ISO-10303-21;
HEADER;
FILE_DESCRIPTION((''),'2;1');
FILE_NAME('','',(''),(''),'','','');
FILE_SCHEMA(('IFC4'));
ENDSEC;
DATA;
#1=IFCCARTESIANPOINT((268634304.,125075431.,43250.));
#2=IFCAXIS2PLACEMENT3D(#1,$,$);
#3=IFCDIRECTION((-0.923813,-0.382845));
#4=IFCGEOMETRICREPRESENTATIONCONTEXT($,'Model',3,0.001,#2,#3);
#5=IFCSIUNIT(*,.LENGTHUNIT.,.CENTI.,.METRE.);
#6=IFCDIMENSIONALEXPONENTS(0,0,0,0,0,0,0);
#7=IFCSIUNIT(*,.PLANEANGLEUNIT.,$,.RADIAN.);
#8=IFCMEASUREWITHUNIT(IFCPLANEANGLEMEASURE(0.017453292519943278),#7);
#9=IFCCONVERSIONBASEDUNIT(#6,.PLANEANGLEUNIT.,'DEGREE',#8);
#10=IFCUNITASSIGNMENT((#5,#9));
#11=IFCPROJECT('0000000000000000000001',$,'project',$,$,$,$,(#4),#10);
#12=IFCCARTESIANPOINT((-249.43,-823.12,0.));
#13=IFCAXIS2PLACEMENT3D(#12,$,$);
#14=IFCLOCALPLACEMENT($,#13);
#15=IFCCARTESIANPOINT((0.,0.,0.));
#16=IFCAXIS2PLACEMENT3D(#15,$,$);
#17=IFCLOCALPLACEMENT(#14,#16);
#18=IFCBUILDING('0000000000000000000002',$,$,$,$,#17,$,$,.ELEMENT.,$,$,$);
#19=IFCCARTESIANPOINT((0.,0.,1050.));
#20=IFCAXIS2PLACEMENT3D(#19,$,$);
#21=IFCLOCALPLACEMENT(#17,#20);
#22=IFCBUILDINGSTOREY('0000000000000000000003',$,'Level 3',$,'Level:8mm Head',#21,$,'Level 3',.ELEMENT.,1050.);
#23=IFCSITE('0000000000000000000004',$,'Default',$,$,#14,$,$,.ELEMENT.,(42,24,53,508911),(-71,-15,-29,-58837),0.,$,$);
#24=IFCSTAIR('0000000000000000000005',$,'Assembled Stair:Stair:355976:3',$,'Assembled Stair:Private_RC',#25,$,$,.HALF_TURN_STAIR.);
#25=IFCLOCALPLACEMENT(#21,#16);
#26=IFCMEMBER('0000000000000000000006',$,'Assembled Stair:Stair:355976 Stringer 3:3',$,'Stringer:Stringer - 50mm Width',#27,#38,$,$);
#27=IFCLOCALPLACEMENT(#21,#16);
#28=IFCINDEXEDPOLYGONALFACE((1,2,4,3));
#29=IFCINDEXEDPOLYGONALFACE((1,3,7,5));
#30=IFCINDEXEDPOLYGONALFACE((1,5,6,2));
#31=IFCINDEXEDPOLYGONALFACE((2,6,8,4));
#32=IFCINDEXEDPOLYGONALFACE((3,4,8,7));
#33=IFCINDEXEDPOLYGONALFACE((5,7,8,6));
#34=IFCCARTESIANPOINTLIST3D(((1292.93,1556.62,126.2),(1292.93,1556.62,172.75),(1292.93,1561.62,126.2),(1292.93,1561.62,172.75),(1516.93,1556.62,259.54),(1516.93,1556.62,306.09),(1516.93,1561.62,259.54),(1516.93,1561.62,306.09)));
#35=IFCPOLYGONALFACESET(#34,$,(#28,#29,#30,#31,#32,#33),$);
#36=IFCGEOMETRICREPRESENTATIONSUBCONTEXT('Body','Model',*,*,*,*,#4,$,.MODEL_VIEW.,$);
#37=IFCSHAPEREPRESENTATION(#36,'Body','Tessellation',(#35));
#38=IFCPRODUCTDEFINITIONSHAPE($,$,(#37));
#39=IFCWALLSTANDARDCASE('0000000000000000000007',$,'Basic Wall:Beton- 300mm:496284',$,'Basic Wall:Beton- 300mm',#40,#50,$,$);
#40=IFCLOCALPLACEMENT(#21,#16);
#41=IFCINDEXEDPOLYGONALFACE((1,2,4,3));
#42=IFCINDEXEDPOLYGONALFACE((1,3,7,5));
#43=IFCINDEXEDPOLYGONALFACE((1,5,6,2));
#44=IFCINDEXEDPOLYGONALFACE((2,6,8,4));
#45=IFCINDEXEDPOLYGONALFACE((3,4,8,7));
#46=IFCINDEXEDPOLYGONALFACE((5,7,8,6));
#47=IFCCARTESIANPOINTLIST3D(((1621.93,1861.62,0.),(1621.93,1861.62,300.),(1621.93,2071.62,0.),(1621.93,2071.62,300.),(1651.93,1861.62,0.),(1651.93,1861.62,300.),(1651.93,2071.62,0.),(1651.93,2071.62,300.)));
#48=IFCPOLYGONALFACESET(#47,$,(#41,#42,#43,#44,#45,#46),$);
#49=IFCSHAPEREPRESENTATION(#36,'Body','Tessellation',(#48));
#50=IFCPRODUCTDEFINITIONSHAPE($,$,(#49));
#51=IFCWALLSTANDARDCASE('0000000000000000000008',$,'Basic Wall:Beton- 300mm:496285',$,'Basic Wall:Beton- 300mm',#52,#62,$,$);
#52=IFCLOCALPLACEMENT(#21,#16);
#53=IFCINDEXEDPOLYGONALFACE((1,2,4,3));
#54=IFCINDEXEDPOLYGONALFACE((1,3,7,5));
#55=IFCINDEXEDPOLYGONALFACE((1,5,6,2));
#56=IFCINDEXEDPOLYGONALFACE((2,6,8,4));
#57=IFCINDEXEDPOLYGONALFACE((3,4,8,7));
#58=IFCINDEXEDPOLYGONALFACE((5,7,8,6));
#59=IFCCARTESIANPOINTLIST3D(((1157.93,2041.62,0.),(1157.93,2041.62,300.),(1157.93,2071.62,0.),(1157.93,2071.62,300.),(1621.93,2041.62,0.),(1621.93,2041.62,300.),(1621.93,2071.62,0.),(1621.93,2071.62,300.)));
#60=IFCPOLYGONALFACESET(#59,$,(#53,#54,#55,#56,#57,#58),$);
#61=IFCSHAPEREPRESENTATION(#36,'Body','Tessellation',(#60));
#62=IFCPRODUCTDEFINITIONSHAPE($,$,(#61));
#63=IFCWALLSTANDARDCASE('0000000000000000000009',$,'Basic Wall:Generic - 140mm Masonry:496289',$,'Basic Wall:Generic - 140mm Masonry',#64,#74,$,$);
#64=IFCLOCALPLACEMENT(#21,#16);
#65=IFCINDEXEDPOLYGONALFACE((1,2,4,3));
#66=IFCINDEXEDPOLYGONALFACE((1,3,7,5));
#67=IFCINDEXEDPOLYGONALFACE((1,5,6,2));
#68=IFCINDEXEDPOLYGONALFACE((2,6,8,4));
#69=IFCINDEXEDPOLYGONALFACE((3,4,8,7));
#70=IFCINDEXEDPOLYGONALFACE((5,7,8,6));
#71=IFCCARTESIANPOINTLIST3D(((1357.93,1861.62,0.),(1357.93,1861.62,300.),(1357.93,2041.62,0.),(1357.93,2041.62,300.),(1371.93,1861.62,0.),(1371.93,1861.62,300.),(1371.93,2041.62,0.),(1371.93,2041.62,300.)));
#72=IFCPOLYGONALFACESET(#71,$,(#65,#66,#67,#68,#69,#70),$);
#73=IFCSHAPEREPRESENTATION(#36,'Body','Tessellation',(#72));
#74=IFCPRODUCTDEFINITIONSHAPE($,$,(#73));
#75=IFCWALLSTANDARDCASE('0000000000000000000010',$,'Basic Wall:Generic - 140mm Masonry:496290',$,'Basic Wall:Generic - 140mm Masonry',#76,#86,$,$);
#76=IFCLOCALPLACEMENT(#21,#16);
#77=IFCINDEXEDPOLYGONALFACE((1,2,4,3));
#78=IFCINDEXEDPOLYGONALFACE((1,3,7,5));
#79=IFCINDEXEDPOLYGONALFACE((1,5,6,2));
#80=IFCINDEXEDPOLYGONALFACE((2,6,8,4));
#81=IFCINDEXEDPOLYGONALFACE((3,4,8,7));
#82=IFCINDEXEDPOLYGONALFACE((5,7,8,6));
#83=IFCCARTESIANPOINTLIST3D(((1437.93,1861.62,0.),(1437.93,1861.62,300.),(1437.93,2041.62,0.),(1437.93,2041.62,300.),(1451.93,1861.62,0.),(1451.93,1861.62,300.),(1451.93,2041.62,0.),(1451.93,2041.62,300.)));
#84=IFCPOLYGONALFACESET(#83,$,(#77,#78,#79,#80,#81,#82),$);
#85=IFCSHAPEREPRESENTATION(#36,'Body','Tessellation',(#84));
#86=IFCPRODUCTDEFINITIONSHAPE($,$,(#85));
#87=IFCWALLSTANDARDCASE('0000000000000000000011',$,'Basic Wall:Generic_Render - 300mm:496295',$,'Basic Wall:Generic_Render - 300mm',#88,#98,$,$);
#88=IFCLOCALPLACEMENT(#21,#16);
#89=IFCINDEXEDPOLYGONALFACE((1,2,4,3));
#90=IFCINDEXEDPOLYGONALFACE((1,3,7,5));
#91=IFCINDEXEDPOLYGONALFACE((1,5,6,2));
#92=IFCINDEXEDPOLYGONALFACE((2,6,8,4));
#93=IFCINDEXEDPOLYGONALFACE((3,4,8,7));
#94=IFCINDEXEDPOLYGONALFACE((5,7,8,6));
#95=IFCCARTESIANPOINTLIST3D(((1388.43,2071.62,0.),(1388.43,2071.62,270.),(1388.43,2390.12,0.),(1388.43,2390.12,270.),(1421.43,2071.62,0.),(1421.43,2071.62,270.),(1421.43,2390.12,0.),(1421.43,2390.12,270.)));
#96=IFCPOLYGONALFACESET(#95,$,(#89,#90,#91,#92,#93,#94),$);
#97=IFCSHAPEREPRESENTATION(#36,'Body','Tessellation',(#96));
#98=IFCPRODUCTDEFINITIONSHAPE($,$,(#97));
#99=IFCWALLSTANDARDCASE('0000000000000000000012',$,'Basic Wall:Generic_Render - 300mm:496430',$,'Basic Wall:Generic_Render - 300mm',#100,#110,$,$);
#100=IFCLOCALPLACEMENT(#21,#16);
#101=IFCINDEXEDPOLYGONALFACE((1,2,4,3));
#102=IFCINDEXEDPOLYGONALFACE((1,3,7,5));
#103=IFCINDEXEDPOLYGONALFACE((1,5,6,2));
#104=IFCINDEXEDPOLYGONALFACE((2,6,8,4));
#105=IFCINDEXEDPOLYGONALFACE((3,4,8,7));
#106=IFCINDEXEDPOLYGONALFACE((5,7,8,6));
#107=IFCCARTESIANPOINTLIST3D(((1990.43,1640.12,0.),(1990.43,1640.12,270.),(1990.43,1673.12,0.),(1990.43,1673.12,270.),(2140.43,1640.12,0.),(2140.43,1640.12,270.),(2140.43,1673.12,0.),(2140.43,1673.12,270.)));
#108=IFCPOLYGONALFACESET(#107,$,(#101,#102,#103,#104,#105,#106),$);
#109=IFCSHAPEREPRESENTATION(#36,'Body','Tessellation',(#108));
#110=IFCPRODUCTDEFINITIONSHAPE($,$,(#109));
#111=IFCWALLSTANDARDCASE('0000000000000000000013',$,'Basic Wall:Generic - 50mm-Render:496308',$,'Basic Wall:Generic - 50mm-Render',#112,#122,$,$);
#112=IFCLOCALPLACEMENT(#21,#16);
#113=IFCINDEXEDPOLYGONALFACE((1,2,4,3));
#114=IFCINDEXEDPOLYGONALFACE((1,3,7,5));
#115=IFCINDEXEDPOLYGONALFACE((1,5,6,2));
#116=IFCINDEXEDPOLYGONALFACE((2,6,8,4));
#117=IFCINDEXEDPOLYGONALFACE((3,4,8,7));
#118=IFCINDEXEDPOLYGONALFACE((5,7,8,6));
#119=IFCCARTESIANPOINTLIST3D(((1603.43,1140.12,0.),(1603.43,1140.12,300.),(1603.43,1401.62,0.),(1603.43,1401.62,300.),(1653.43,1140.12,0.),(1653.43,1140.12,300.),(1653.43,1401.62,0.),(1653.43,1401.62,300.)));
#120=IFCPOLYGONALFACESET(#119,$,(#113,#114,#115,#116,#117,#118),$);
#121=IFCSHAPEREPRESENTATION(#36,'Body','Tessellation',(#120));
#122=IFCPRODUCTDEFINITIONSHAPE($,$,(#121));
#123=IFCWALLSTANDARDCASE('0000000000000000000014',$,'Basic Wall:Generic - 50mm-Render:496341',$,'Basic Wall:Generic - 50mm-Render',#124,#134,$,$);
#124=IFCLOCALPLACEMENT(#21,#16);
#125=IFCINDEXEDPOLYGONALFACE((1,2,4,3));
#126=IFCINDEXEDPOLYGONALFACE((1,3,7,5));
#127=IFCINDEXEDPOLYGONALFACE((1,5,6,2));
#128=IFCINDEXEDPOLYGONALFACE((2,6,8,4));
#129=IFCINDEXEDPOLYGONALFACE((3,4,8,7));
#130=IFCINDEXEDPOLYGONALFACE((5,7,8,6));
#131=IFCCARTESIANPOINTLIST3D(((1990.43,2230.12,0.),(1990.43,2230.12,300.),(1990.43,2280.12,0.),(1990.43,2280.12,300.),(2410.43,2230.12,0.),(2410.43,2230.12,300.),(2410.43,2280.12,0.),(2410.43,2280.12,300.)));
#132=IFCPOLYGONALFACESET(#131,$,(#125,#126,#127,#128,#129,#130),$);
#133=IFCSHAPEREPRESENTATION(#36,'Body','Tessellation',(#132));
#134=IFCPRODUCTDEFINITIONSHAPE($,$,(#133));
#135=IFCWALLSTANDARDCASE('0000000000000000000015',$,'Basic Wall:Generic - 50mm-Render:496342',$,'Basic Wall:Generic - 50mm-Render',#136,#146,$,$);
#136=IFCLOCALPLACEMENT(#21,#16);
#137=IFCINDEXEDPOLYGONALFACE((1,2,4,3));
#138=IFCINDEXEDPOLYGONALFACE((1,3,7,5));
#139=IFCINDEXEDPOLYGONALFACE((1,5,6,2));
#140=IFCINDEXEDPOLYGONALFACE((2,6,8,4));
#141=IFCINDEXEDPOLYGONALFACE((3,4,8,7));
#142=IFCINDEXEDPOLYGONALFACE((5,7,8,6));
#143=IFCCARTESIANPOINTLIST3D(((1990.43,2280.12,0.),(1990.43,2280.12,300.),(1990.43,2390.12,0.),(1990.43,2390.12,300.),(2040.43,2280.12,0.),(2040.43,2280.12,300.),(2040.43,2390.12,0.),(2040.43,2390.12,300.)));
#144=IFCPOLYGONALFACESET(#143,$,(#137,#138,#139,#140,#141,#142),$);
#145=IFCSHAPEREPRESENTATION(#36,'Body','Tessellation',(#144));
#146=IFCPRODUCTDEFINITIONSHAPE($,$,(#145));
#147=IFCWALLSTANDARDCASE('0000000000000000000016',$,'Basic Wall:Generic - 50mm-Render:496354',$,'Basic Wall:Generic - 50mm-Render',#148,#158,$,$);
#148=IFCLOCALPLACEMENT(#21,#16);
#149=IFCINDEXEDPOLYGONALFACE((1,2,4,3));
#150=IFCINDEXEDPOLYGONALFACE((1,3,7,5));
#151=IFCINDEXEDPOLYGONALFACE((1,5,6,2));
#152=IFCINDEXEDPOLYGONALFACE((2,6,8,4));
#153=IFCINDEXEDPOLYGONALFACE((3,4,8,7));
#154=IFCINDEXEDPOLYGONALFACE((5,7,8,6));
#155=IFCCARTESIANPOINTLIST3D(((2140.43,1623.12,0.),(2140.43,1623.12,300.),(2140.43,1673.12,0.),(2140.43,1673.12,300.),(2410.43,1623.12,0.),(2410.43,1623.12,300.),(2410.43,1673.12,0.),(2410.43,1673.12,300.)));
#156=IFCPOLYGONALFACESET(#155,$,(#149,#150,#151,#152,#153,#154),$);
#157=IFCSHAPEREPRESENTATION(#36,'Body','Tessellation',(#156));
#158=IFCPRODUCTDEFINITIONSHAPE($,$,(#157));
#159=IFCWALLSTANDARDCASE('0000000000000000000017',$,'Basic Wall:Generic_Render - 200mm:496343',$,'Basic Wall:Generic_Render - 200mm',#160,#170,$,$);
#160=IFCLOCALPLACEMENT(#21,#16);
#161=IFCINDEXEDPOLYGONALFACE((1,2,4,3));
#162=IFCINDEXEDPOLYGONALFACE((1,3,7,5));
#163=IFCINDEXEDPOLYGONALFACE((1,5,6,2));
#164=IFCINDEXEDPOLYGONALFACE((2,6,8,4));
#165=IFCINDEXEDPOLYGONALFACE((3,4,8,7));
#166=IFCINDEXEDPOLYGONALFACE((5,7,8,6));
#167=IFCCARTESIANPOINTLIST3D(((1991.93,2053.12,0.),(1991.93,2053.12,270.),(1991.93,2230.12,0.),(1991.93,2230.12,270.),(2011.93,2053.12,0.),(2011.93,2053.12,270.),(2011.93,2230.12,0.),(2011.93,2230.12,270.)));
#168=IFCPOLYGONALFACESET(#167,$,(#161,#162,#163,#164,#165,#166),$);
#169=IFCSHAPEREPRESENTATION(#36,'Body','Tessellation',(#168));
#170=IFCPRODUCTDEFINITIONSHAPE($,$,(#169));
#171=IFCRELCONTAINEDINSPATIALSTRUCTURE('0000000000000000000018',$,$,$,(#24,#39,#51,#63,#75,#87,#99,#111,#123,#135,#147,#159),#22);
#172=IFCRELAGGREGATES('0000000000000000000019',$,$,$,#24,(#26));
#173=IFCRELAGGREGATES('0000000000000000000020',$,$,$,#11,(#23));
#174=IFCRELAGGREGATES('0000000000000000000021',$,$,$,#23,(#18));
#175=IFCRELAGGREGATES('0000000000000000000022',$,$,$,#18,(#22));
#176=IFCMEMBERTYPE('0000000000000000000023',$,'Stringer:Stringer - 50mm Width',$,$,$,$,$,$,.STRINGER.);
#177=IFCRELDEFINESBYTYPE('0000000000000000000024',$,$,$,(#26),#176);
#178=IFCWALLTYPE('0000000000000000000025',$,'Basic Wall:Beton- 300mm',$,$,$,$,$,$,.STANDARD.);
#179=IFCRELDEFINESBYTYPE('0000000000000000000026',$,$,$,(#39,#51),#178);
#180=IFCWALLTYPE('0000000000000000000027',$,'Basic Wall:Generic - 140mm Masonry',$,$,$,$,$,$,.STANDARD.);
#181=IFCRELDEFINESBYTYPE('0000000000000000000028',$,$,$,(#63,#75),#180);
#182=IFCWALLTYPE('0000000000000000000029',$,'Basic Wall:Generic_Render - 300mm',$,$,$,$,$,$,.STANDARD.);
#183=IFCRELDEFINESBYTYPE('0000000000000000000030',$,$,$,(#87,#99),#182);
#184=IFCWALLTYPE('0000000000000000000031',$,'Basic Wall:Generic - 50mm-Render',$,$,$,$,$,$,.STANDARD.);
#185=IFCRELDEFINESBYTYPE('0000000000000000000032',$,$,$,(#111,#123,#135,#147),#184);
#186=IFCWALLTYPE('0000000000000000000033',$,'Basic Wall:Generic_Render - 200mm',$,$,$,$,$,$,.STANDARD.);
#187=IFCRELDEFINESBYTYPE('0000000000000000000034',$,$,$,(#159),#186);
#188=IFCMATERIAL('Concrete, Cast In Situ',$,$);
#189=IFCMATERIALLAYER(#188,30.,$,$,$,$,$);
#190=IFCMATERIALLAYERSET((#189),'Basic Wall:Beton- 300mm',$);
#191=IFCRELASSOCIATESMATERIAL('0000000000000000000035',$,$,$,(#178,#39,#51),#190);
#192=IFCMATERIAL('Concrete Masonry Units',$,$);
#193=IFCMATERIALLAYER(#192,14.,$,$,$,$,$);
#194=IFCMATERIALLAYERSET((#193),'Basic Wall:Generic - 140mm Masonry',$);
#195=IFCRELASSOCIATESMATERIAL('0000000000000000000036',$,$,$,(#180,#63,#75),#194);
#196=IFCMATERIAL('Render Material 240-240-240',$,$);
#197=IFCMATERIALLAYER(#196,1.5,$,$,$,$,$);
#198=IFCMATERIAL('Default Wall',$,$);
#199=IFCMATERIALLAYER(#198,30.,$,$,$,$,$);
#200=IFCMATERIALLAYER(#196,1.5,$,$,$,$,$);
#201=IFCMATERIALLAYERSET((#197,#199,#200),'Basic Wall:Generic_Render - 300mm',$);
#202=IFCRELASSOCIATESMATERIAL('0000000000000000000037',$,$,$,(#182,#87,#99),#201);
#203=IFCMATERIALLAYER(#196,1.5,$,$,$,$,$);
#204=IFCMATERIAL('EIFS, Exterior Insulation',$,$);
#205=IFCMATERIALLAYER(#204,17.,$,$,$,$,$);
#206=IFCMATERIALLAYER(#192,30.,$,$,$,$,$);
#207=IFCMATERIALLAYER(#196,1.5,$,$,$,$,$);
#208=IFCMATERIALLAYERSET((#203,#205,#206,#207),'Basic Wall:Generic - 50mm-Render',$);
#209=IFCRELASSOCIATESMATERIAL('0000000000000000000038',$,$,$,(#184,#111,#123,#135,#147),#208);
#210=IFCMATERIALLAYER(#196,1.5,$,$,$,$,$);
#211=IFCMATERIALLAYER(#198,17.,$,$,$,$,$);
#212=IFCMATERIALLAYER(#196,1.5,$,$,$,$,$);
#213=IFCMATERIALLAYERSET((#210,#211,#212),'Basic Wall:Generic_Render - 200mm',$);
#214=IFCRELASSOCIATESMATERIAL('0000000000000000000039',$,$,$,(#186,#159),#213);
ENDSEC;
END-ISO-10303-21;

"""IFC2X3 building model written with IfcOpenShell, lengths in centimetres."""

from ifc_helpers import new_model, entity, si_unit, converted_unit, direction, frame, frame_2d, origin, place, context, subcontext, project, spatial, polyline, rectangle, outline, extrude, material, layer, layer_set, layer_usage, type_object, element, aggregate, save


model = new_model("IFC2X3")

# Units and contexts
model_context = context("Model", 3, precision=0.001, world=frame((268634304.0, 125075431.0, 43250.0)), true_north=direction((-0.923813, -0.382845)))
body_context = subcontext(model_context, "Body", "Model", "MODEL_VIEW")
ifc_project = project(units=[si_unit("LENGTHUNIT", "METRE", prefix="CENTI"), converted_unit("PLANEANGLEUNIT", "DEGREE", entity("IfcPlaneAngleMeasure", 0.017453292519943278), si_unit("PLANEANGLEUNIT", "RADIAN"), dimensions=[0, 0, 0, 0, 0, 0, 0])], contexts=[model_context])

# Site, building, storey
site_placement = place(None, frame((-249.43, -823.12, 0.0)))
site = spatial("IfcSite", under=ifc_project, at=site_placement, Name="Default", CompositionType="ELEMENT", RefLatitude=(42, 24, 53, 508911), RefLongitude=(-71, -15, -29, -58837), RefElevation=0.0)
building_placement = place(site_placement, origin())
building = spatial("IfcBuilding", under=site, at=building_placement, CompositionType="ELEMENT")
storey_placement = place(building_placement, frame((0.0, 0.0, 1050.0)))
storey = spatial("IfcBuildingStorey", under=building, at=storey_placement, Name="Level 3", ObjectType="Level:8mm Head", LongName="Level 3", CompositionType="ELEMENT", Elevation=1050.0)

# Stair, member
stair_placement = place(storey_placement, origin())
stair = element("IfcStair", 1, at=stair_placement, inside=storey, Name="Assembled Stair:Stair:355976:3", ObjectType="Assembled Stair:Private_RC", ShapeType="HALF_TURN_STAIR")
member_type = type_object("IfcMemberType", Name="Stringer:Stringer - 50mm Width", PredefinedType="STRINGER")
member_1_placement = place(stair_placement, frame((1292.93, 1556.62, 126.2)))
member_1 = element("IfcMember", 2, at=member_1_placement, type_object=member_type, Name="Assembled Stair:Stair:355976 Stringer 3:3", ObjectType="Stringer:Stringer - 50mm Width", context=body_context, shape_type="SweptSolid", body=[
    extrude(outline(polyline([(-118.43, -20.0), (142.24, -20.0), (118.43, 20.0), (-142.24, 20.0), (-118.43, -20.0)])), frame((112.0, 0.0, 89.94), z_axis=(0.0, 1.0, 0.0), x_axis=(0.859293, 0.0, 0.511484)), (0.0, 0.0, 1.0), 5.0),
])
aggregate(stair, [member_1])

# Walls
ifc_material_1 = material(Name="Concrete, Cast In Situ")
ifc_layer_1 = layer(ifc_material_1, 30.0)
ifc_layer_set_1 = layer_set([ifc_layer_1], Name="Basic Wall:Beton- 300mm")
ifc_layer_usage_1 = layer_usage(ifc_layer_set_1, "AXIS2", "POSITIVE", -15.0)
wall_type_1 = type_object("IfcWallType", Name="Basic Wall:Beton- 300mm", PredefinedType="STANDARD", material=ifc_layer_set_1)
wall_1_placement = place(storey_placement, frame((1636.93, 1861.62, 0.0), z_axis=(0.0, 0.0, 1.0), x_axis=(0.0, 1.0, 0.0)))
element("IfcWallStandardCase", 3, at=wall_1_placement, inside=storey, type_object=wall_type_1, material=ifc_layer_usage_1, Name="Basic Wall:Beton- 300mm:496284", ObjectType="Basic Wall:Beton- 300mm", context=body_context, shape_type="SweptSolid", body=[
    extrude(rectangle(XDim=210.0, YDim=30.0, at=frame_2d((105.0, 0.0), x_axis=(-1.0, 0.0))), origin(), (0.0, 0.0, 1.0), 300.0),
])
ifc_layer_usage_2 = layer_usage(ifc_layer_set_1, "AXIS2", "NEGATIVE", 15.0)
wall_2_placement = place(storey_placement, frame((1621.93, 2056.62, 0.0), z_axis=(0.0, 0.0, 1.0), x_axis=(-1.0, 0.0, 0.0)))
element("IfcWallStandardCase", 4, at=wall_2_placement, inside=storey, type_object=wall_type_1, material=ifc_layer_usage_2, Name="Basic Wall:Beton- 300mm:496285", ObjectType="Basic Wall:Beton- 300mm", context=body_context, shape_type="SweptSolid", body=[
    extrude(rectangle(XDim=464.0, YDim=30.0, at=frame_2d((232.0, 0.0), x_axis=(-1.0, 0.0))), origin(), (0.0, 0.0, 1.0), 300.0),
])

# Walls
ifc_material_2 = material(Name="Concrete Masonry Units")
ifc_layer_2 = layer(ifc_material_2, 14.0)
ifc_layer_set_2 = layer_set([ifc_layer_2], Name="Basic Wall:Generic - 140mm Masonry")
ifc_layer_usage_3 = layer_usage(ifc_layer_set_2, "AXIS2", "POSITIVE", -7.0)
wall_type_2 = type_object("IfcWallType", Name="Basic Wall:Generic - 140mm Masonry", PredefinedType="STANDARD", material=ifc_layer_set_2)
wall_3_placement = place(storey_placement, frame((1364.93, 2041.62, 0.0), z_axis=(0.0, 0.0, 1.0), x_axis=(0.0, -1.0, 0.0)))
element("IfcWallStandardCase", 5, at=wall_3_placement, inside=storey, type_object=wall_type_2, material=ifc_layer_usage_3, Name="Basic Wall:Generic - 140mm Masonry:496289", ObjectType="Basic Wall:Generic - 140mm Masonry", context=body_context, shape_type="SweptSolid", body=[
    extrude(rectangle(XDim=180.0, YDim=14.0, at=frame_2d((90.0, 0.0), x_axis=(-1.0, 0.0))), origin(), (0.0, 0.0, 1.0), 300.0),
])
ifc_layer_usage_4 = layer_usage(ifc_layer_set_2, "AXIS2", "POSITIVE", -7.0)
wall_4_placement = place(storey_placement, frame((1444.93, 2041.62, 0.0), z_axis=(0.0, 0.0, 1.0), x_axis=(0.0, -1.0, 0.0)))
element("IfcWallStandardCase", 6, at=wall_4_placement, inside=storey, type_object=wall_type_2, material=ifc_layer_usage_4, Name="Basic Wall:Generic - 140mm Masonry:496290", ObjectType="Basic Wall:Generic - 140mm Masonry", context=body_context, shape_type="SweptSolid", body=[
    extrude(rectangle(XDim=180.0, YDim=14.0, at=frame_2d((90.0, 0.0), x_axis=(-1.0, 0.0))), origin(), (0.0, 0.0, 1.0), 300.0),
])
ifc_material_3 = material(Name="Render Material 240-240-240")
ifc_layer_3 = layer(ifc_material_3, 1.5)
ifc_material_4 = material(Name="Default Wall")
ifc_layer_4 = layer(ifc_material_4, 30.0)
ifc_layer_5 = layer(ifc_material_3, 1.5)
ifc_layer_set_3 = layer_set([ifc_layer_3, ifc_layer_4, ifc_layer_5], Name="Basic Wall:Generic_Render - 300mm")
ifc_layer_usage_5 = layer_usage(ifc_layer_set_3, "AXIS2", "NEGATIVE", 16.5)
wall_type_3 = type_object("IfcWallType", Name="Basic Wall:Generic_Render - 300mm", PredefinedType="STANDARD", material=ifc_layer_set_3)
wall_5_placement = place(storey_placement, frame((1404.93, 2071.62, 0.0), z_axis=(0.0, 0.0, 1.0), x_axis=(0.0, 1.0, 0.0)))
element("IfcWallStandardCase", 7, at=wall_5_placement, inside=storey, type_object=wall_type_3, material=ifc_layer_usage_5, Name="Basic Wall:Generic_Render - 300mm:496295", ObjectType="Basic Wall:Generic_Render - 300mm", context=body_context, shape_type="SweptSolid", body=[
    extrude(rectangle(XDim=318.5, YDim=33.0, at=frame_2d((159.25, 0.0), x_axis=(-1.0, 0.0))), origin(), (0.0, 0.0, 1.0), 270.0),
])
ifc_layer_usage_6 = layer_usage(ifc_layer_set_3, "AXIS2", "NEGATIVE", 16.5)
wall_6_placement = place(storey_placement, frame((1990.43, 1656.62, 0.0)))
element("IfcWallStandardCase", 8, at=wall_6_placement, inside=storey, type_object=wall_type_3, material=ifc_layer_usage_6, Name="Basic Wall:Generic_Render - 300mm:496430", ObjectType="Basic Wall:Generic_Render - 300mm", context=body_context, shape_type="SweptSolid", body=[
    extrude(rectangle(XDim=150.0, YDim=33.0, at=frame_2d((75.0, 0.0), x_axis=(-1.0, 0.0))), origin(), (0.0, 0.0, 1.0), 270.0),
])
ifc_layer_6 = layer(ifc_material_3, 1.5)
ifc_material_5 = material(Name="EIFS, Exterior Insulation")
ifc_layer_7 = layer(ifc_material_5, 17.0)
ifc_layer_8 = layer(ifc_material_2, 30.0)
ifc_layer_9 = layer(ifc_material_3, 1.5)
ifc_layer_set_4 = layer_set([ifc_layer_6, ifc_layer_7, ifc_layer_8, ifc_layer_9], Name="Basic Wall:Generic - 50mm-Render")
ifc_layer_usage_7 = layer_usage(ifc_layer_set_4, "AXIS2", "POSITIVE", -25.0)
wall_type_4 = type_object("IfcWallType", Name="Basic Wall:Generic - 50mm-Render", PredefinedType="STANDARD", material=ifc_layer_set_4)
wall_7_placement = place(storey_placement, frame((1628.43, 1401.62, 0.0), z_axis=(0.0, 0.0, 1.0), x_axis=(0.0, -1.0, 0.0)))
element("IfcWallStandardCase", 9, at=wall_7_placement, inside=storey, type_object=wall_type_4, material=ifc_layer_usage_7, Name="Basic Wall:Generic - 50mm-Render:496308", ObjectType="Basic Wall:Generic - 50mm-Render", context=body_context, shape_type="SweptSolid", body=[
    extrude(rectangle(XDim=261.5, YDim=50.0, at=frame_2d((130.75, 0.0), x_axis=(-1.0, 0.0))), origin(), (0.0, 0.0, 1.0), 300.0),
])
ifc_layer_usage_8 = layer_usage(ifc_layer_set_4, "AXIS2", "NEGATIVE", 25.0)
wall_8_placement = place(storey_placement, frame((1990.43, 2255.12, 0.0)))
element("IfcWallStandardCase", 10, at=wall_8_placement, inside=storey, type_object=wall_type_4, material=ifc_layer_usage_8, Name="Basic Wall:Generic - 50mm-Render:496341", ObjectType="Basic Wall:Generic - 50mm-Render", context=body_context, shape_type="SweptSolid", body=[
    extrude(rectangle(XDim=420.0, YDim=50.0, at=frame_2d((210.0, 0.0), x_axis=(-1.0, 0.0))), origin(), (0.0, 0.0, 1.0), 300.0),
])
ifc_layer_usage_9 = layer_usage(ifc_layer_set_4, "AXIS2", "POSITIVE", -25.0)
wall_9_placement = place(storey_placement, frame((2015.43, 2280.12, 0.0), z_axis=(0.0, 0.0, 1.0), x_axis=(0.0, 1.0, 0.0)))
element("IfcWallStandardCase", 11, at=wall_9_placement, inside=storey, type_object=wall_type_4, material=ifc_layer_usage_9, Name="Basic Wall:Generic - 50mm-Render:496342", ObjectType="Basic Wall:Generic - 50mm-Render", context=body_context, shape_type="SweptSolid", body=[
    extrude(rectangle(XDim=110.0, YDim=50.0, at=frame_2d((55.0, 0.0), x_axis=(-1.0, 0.0))), origin(), (0.0, 0.0, 1.0), 300.0),
])
ifc_layer_usage_10 = layer_usage(ifc_layer_set_4, "AXIS2", "POSITIVE", -25.0)
wall_10_placement = place(storey_placement, frame((2140.43, 1648.12, 0.0)))
element("IfcWallStandardCase", 12, at=wall_10_placement, inside=storey, type_object=wall_type_4, material=ifc_layer_usage_10, Name="Basic Wall:Generic - 50mm-Render:496354", ObjectType="Basic Wall:Generic - 50mm-Render", context=body_context, shape_type="SweptSolid", body=[
    extrude(rectangle(XDim=270.0, YDim=50.0, at=frame_2d((135.0, 0.0), x_axis=(-1.0, 0.0))), origin(), (0.0, 0.0, 1.0), 300.0),
])
ifc_layer_10 = layer(ifc_material_3, 1.5)
ifc_layer_11 = layer(ifc_material_4, 17.0)
ifc_layer_12 = layer(ifc_material_3, 1.5)
ifc_layer_set_5 = layer_set([ifc_layer_10, ifc_layer_11, ifc_layer_12], Name="Basic Wall:Generic_Render - 200mm")
ifc_layer_usage_11 = layer_usage(ifc_layer_set_5, "AXIS2", "NEGATIVE", 10.0)
wall_type_5 = type_object("IfcWallType", Name="Basic Wall:Generic_Render - 200mm", PredefinedType="STANDARD", material=ifc_layer_set_5)
wall_11_placement = place(storey_placement, frame((2001.93, 2230.12, 0.0), z_axis=(0.0, 0.0, 1.0), x_axis=(0.0, -1.0, 0.0)))
element("IfcWallStandardCase", 13, at=wall_11_placement, inside=storey, type_object=wall_type_5, material=ifc_layer_usage_11, Name="Basic Wall:Generic_Render - 200mm:496343", ObjectType="Basic Wall:Generic_Render - 200mm", context=body_context, shape_type="SweptSolid", body=[
    extrude(rectangle(XDim=177.0, YDim=20.0, at=frame_2d((88.5, 0.0), x_axis=(-1.0, 0.0))), origin(), (0.0, 0.0, 1.0), 270.0),
])

save(model, "model.ifc")
